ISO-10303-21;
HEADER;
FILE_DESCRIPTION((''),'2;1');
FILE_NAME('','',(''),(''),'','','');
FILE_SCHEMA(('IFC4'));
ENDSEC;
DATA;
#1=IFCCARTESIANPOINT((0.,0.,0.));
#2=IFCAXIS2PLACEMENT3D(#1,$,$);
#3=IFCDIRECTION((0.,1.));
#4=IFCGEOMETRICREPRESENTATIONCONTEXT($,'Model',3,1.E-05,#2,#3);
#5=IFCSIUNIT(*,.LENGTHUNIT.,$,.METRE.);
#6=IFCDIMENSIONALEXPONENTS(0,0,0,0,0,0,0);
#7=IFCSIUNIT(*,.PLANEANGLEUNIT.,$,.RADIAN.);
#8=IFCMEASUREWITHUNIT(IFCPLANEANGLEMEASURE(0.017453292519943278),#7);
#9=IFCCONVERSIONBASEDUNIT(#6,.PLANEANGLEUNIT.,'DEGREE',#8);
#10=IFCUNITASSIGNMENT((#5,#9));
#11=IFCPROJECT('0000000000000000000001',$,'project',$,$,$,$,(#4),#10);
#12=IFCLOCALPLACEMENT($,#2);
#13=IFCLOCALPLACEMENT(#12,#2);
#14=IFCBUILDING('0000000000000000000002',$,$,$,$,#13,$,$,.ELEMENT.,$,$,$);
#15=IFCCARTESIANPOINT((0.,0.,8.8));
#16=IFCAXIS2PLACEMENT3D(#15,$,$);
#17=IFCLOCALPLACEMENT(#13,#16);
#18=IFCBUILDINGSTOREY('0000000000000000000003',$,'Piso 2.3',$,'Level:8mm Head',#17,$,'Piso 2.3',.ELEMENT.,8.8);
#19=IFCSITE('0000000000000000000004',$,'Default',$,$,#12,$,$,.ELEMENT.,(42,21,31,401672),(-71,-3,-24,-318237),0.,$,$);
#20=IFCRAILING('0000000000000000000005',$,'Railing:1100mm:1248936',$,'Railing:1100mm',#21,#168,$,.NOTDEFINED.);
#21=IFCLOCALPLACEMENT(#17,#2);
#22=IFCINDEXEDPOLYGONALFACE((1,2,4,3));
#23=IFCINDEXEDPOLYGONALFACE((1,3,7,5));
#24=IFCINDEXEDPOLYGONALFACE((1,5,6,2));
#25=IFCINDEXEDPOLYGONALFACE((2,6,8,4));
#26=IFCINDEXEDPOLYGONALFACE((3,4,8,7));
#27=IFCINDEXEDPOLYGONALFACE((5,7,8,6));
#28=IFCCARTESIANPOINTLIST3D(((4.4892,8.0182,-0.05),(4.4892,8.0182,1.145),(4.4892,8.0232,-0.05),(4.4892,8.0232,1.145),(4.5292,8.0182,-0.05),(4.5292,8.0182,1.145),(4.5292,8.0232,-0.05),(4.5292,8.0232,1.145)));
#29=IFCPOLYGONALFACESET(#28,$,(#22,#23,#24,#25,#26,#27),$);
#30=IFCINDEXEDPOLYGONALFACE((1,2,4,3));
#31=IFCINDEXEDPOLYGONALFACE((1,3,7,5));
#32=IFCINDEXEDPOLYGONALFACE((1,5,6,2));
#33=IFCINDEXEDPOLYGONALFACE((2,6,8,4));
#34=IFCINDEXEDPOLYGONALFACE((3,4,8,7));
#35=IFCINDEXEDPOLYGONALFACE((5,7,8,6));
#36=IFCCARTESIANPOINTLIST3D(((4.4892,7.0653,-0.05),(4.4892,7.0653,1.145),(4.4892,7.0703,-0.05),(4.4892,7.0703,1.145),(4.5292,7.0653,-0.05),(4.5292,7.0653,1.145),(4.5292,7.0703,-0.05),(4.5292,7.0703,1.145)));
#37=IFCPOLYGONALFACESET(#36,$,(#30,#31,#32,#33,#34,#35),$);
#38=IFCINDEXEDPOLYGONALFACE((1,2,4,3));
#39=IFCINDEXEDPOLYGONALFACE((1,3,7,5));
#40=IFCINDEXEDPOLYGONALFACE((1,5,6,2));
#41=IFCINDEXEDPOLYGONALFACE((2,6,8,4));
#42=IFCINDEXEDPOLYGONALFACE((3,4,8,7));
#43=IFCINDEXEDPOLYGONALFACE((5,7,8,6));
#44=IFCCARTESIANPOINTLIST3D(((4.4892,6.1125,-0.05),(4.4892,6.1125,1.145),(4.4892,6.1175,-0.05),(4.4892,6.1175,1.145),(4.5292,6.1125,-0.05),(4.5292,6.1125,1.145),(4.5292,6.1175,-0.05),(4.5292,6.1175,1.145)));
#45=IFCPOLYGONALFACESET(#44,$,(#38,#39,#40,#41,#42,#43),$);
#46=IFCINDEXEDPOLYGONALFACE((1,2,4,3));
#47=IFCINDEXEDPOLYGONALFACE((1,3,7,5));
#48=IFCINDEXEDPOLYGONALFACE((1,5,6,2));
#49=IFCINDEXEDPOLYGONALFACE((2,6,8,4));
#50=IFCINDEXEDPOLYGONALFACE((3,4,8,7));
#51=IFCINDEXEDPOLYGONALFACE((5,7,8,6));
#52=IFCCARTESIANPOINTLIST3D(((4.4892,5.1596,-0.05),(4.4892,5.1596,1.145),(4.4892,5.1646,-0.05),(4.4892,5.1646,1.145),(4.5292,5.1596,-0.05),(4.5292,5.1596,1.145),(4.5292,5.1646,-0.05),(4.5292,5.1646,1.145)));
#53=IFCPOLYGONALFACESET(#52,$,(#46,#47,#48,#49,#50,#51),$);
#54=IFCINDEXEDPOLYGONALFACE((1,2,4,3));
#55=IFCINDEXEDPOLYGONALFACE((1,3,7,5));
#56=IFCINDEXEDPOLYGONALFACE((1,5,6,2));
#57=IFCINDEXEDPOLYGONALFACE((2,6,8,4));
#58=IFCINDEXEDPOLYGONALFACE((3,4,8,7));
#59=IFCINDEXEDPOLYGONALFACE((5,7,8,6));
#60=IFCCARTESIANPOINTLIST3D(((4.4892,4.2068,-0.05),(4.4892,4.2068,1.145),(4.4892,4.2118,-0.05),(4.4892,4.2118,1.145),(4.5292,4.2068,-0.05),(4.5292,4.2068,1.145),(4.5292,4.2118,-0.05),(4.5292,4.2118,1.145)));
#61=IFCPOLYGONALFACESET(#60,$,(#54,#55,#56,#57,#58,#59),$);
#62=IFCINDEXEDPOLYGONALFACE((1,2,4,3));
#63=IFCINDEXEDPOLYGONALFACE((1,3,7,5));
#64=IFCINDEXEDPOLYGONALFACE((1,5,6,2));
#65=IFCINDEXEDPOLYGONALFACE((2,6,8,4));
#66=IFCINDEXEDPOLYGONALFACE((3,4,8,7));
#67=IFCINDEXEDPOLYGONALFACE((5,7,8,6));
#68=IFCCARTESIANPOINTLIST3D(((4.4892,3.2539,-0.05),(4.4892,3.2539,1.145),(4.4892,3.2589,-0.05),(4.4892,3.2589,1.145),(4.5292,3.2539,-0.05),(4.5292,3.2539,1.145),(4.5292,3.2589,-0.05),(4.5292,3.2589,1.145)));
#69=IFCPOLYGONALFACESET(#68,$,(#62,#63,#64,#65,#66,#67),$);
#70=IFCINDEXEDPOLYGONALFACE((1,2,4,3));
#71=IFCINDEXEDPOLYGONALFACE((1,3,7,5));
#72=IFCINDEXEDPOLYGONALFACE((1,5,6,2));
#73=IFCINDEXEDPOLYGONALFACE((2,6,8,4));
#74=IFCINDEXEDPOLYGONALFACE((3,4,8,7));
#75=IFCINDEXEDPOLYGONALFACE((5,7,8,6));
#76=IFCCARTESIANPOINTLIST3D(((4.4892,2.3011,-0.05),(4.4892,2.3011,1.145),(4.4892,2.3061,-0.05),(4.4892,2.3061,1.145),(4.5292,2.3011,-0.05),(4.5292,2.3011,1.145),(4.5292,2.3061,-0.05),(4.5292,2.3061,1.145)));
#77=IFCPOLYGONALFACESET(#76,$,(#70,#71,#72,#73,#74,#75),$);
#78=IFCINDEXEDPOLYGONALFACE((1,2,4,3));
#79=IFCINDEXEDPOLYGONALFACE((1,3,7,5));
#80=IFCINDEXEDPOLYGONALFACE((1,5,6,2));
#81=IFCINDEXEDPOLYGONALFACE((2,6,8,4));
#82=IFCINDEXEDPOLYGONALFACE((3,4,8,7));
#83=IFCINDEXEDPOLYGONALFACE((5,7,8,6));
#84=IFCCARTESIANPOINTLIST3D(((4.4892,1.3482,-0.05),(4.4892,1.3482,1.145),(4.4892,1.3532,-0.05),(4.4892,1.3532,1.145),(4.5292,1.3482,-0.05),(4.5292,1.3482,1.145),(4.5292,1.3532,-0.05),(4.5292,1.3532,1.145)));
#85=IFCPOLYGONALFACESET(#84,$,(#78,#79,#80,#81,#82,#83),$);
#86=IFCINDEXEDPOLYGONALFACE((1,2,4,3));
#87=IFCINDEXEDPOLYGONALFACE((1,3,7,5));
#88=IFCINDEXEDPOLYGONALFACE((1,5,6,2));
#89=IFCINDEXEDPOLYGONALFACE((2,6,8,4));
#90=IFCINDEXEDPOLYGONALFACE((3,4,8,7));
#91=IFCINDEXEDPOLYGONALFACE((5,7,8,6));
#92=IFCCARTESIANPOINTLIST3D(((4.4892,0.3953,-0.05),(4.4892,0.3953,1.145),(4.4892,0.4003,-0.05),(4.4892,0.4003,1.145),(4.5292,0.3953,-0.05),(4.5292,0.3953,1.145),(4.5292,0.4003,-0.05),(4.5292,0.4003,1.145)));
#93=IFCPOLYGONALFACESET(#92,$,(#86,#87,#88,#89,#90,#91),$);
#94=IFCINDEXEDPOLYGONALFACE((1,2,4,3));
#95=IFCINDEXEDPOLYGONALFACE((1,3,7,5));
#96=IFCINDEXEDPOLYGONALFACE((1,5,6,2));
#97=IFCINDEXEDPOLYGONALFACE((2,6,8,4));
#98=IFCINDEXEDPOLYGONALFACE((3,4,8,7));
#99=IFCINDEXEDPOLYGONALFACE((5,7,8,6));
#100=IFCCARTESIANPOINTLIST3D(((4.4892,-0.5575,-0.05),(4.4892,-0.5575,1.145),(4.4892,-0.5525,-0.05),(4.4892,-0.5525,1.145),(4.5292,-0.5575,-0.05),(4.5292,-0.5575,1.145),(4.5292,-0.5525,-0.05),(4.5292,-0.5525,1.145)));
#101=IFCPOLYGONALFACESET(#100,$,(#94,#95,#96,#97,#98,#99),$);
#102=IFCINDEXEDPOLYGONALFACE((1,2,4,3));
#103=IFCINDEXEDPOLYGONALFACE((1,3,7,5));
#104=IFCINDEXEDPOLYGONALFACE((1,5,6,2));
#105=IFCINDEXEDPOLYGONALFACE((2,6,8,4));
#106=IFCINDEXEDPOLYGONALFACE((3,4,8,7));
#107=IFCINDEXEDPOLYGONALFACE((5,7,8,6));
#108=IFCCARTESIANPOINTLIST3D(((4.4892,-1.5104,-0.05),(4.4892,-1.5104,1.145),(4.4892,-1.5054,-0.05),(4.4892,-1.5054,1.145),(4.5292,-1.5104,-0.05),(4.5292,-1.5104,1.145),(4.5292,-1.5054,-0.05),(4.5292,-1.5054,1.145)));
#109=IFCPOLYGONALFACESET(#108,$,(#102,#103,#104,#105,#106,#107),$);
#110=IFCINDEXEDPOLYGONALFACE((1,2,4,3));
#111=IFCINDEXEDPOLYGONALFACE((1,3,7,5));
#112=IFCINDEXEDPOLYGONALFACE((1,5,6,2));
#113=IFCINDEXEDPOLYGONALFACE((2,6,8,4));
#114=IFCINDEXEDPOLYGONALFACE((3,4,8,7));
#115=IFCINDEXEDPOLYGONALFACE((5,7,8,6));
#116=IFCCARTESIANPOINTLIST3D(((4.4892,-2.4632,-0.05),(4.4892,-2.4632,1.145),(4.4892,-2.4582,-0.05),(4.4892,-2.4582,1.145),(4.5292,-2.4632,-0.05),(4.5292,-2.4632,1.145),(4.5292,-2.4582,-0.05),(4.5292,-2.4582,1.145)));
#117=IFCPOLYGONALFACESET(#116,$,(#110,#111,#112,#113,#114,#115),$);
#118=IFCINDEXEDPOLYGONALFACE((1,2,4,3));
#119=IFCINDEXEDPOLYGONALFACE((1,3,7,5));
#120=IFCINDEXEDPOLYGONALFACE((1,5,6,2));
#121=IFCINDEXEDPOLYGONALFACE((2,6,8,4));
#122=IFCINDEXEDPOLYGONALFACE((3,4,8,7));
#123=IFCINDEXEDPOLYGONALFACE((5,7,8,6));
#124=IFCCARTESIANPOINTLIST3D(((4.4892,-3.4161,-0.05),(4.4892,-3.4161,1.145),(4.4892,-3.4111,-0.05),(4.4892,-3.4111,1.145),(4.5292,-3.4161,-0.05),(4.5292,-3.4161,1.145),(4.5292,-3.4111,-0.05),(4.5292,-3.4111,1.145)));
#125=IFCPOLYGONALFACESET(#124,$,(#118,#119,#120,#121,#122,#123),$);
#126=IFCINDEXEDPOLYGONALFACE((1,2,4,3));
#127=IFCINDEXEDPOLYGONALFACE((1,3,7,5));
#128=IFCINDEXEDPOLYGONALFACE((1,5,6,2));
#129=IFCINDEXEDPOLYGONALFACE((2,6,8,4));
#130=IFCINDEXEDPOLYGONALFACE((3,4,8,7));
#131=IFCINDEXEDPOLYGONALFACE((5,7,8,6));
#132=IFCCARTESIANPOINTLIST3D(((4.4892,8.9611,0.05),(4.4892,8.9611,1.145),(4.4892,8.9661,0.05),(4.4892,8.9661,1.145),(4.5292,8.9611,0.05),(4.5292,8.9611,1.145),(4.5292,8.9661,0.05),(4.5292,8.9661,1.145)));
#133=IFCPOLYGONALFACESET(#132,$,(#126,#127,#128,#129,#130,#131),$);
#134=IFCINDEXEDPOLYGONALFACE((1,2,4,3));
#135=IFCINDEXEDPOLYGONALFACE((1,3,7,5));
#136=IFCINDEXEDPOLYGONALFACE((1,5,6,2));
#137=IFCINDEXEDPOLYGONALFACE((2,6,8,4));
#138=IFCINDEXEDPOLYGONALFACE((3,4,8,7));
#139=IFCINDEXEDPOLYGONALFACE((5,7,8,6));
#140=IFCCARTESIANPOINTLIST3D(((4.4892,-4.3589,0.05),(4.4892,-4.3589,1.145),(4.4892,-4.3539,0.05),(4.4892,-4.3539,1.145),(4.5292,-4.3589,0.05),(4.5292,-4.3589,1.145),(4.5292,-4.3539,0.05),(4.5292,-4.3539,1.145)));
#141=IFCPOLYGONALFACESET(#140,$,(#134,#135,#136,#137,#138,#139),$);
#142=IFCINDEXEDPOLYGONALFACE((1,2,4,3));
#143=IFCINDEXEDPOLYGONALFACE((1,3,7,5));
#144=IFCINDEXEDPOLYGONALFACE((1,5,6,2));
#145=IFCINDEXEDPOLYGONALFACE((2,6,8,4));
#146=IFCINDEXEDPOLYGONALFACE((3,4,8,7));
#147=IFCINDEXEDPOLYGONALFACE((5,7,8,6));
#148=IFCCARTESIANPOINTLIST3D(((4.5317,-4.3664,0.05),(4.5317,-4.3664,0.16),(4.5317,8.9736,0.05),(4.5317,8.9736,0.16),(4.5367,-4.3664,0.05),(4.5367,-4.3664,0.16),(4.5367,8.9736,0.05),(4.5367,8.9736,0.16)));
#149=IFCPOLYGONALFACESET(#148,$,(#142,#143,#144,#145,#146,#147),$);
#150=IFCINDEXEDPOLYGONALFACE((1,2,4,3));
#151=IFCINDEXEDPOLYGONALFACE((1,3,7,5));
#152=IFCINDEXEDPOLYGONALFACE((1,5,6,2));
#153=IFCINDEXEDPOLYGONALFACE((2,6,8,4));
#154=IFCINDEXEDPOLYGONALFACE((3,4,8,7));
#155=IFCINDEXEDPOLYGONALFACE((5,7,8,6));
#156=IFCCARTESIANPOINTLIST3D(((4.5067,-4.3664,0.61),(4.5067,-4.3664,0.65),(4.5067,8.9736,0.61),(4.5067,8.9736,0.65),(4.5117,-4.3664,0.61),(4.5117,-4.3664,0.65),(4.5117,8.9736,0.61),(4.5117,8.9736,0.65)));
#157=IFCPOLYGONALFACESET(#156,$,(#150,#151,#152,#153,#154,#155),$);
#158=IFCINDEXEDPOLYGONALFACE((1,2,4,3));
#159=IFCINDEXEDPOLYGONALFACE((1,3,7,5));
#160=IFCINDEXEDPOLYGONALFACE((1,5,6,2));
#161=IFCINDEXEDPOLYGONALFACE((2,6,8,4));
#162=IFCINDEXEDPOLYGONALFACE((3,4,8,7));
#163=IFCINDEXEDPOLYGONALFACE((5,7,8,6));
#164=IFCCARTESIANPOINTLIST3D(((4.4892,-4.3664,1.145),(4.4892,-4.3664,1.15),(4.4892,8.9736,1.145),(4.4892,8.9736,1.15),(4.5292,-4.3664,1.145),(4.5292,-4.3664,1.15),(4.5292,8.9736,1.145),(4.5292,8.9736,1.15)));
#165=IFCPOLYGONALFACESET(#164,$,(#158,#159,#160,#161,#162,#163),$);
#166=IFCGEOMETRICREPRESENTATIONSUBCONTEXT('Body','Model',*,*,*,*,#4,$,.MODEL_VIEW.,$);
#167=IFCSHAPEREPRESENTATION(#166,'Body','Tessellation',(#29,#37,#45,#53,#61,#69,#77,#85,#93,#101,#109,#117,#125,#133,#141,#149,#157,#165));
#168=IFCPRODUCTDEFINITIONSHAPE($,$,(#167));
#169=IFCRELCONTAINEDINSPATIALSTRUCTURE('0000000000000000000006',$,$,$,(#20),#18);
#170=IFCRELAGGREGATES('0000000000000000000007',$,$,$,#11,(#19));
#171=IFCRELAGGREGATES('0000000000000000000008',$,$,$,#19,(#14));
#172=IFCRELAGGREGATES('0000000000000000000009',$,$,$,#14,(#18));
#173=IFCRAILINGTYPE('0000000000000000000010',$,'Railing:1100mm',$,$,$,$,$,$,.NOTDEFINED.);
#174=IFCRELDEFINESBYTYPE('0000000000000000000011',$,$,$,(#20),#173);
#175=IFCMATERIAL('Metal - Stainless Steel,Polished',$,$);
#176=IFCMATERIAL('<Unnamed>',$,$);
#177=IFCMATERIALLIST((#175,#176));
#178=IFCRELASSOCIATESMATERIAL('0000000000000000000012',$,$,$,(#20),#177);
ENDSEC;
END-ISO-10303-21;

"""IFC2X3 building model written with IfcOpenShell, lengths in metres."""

from ifc_helpers import new_model, entity, si_unit, converted_unit, direction, frame, frame_2d, origin, origin_2d_with_axis, place, context, subcontext, project, spatial, rectangle, extrude, material, material_list, type_object, element, save


model = new_model("IFC2X3")

# Units and contexts
model_context = context("Model", 3, precision=1e-05, world=origin(), true_north=direction((0.0, 1.0)))
body_context = subcontext(model_context, "Body", "Model", "MODEL_VIEW")
ifc_project = project(units=[si_unit("LENGTHUNIT", "METRE"), converted_unit("PLANEANGLEUNIT", "DEGREE", entity("IfcPlaneAngleMeasure", 0.017453292519943278), si_unit("PLANEANGLEUNIT", "RADIAN"), dimensions=[0, 0, 0, 0, 0, 0, 0])], contexts=[model_context])

# Site, building, storey
site_placement = place(None, origin())
site = spatial("IfcSite", under=ifc_project, at=site_placement, Name="Default", CompositionType="ELEMENT", RefLatitude=(42, 21, 31, 401672), RefLongitude=(-71, -3, -24, -318237), RefElevation=0.0)
building_placement = place(site_placement, origin())
building = spatial("IfcBuilding", under=site, at=building_placement, CompositionType="ELEMENT")
storey_placement = place(building_placement, frame((0.0, 0.0, 8.8)))
storey = spatial("IfcBuildingStorey", under=building, at=storey_placement, Name="Piso 2.3", ObjectType="Level:8mm Head", LongName="Piso 2.3", CompositionType="ELEMENT", Elevation=8.8)

# Railing
ifc_material_1 = material(Name="Metal - Stainless Steel,Polished")
ifc_material_2 = material(Name="<Unnamed>")
ifc_material_list = material_list([ifc_material_1, ifc_material_2])
railing_type = type_object("IfcRailingType", Name="Railing:1100mm", PredefinedType="NOTDEFINED")
railing_1_placement = place(storey_placement, origin())
element("IfcRailing", 1, at=railing_1_placement, inside=storey, type_object=railing_type, material=ifc_material_list, Name="Railing:1100mm:1248936", ObjectType="Railing:1100mm", PredefinedType="NOTDEFINED", context=body_context, shape_type="SweptSolid", body=[
    extrude(rectangle(XDim=0.005, YDim=0.04, at=frame_2d((0.0, 0.0), x_axis=(1.0, 0.0))), frame((4.5092, 8.0207, -0.05), z_axis=(0.0, 0.0, 1.0), x_axis=(0.0, 1.0, 0.0)), (0.0, 0.0, 1.0), 1.195),
    extrude(rectangle(XDim=0.005, YDim=0.04, at=frame_2d((0.0, 0.0), x_axis=(1.0, 0.0))), frame((4.5092, 7.0678, -0.05), z_axis=(0.0, 0.0, 1.0), x_axis=(0.0, 1.0, 0.0)), (0.0, 0.0, 1.0), 1.195),
    extrude(rectangle(XDim=0.005, YDim=0.04, at=frame_2d((0.0, 0.0), x_axis=(1.0, 0.0))), frame((4.5092, 6.115, -0.05), z_axis=(0.0, 0.0, 1.0), x_axis=(0.0, 1.0, 0.0)), (0.0, 0.0, 1.0), 1.195),
    extrude(rectangle(XDim=0.005, YDim=0.04, at=frame_2d((0.0, 0.0), x_axis=(1.0, 0.0))), frame((4.5092, 5.1621, -0.05), z_axis=(0.0, 0.0, 1.0), x_axis=(0.0, 1.0, 0.0)), (0.0, 0.0, 1.0), 1.195),
    extrude(rectangle(XDim=0.005, YDim=0.04, at=frame_2d((0.0, 0.0), x_axis=(1.0, 0.0))), frame((4.5092, 4.2093, -0.05), z_axis=(0.0, 0.0, 1.0), x_axis=(0.0, 1.0, 0.0)), (0.0, 0.0, 1.0), 1.195),
    extrude(rectangle(XDim=0.005, YDim=0.04, at=frame_2d((0.0, 0.0), x_axis=(1.0, 0.0))), frame((4.5092, 3.2564, -0.05), z_axis=(0.0, 0.0, 1.0), x_axis=(0.0, 1.0, 0.0)), (0.0, 0.0, 1.0), 1.195),
    extrude(rectangle(XDim=0.005, YDim=0.04, at=frame_2d((0.0, 0.0), x_axis=(1.0, 0.0))), frame((4.5092, 2.3036, -0.05), z_axis=(0.0, 0.0, 1.0), x_axis=(0.0, 1.0, 0.0)), (0.0, 0.0, 1.0), 1.195),
    extrude(rectangle(XDim=0.005, YDim=0.04, at=frame_2d((0.0, 0.0), x_axis=(1.0, 0.0))), frame((4.5092, 1.3507, -0.05), z_axis=(0.0, 0.0, 1.0), x_axis=(0.0, 1.0, 0.0)), (0.0, 0.0, 1.0), 1.195),
    extrude(rectangle(XDim=0.005, YDim=0.04, at=frame_2d((0.0, 0.0), x_axis=(1.0, 0.0))), frame((4.5092, 0.3978, -0.05), z_axis=(0.0, 0.0, 1.0), x_axis=(0.0, 1.0, 0.0)), (0.0, 0.0, 1.0), 1.195),
    extrude(rectangle(XDim=0.005, YDim=0.04, at=frame_2d((0.0, 0.0), x_axis=(1.0, 0.0))), frame((4.5092, -0.555, -0.05), z_axis=(0.0, 0.0, 1.0), x_axis=(0.0, 1.0, 0.0)), (0.0, 0.0, 1.0), 1.195),
    extrude(rectangle(XDim=0.005, YDim=0.04, at=frame_2d((0.0, 0.0), x_axis=(1.0, 0.0))), frame((4.5092, -1.5079, -0.05), z_axis=(0.0, 0.0, 1.0), x_axis=(0.0, 1.0, 0.0)), (0.0, 0.0, 1.0), 1.195),
    extrude(rectangle(XDim=0.005, YDim=0.04, at=frame_2d((0.0, 0.0), x_axis=(1.0, 0.0))), frame((4.5092, -2.4607, -0.05), z_axis=(0.0, 0.0, 1.0), x_axis=(0.0, 1.0, 0.0)), (0.0, 0.0, 1.0), 1.195),
    extrude(rectangle(XDim=0.005, YDim=0.04, at=frame_2d((0.0, 0.0), x_axis=(1.0, 0.0))), frame((4.5092, -3.4136, -0.05), z_axis=(0.0, 0.0, 1.0), x_axis=(0.0, 1.0, 0.0)), (0.0, 0.0, 1.0), 1.195),
    extrude(rectangle(XDim=0.005, YDim=0.04, at=frame_2d((0.0, 0.0), x_axis=(1.0, 0.0))), frame((4.5092, 8.9636, 0.05), z_axis=(0.0, 0.0, 1.0), x_axis=(0.0, 1.0, 0.0)), (0.0, 0.0, 1.0), 1.095),
    extrude(rectangle(XDim=0.005, YDim=0.04, at=frame_2d((0.0, 0.0), x_axis=(1.0, 0.0))), frame((4.5092, -4.3564, 0.05), z_axis=(0.0, 0.0, 1.0), x_axis=(0.0, 1.0, 0.0)), (0.0, 0.0, 1.0), 1.095),
    extrude(rectangle(XDim=13.34, YDim=0.005, at=frame_2d((0.0, 0.0), x_axis=(1.0, 0.0))), frame((4.5342, 2.3036, 0.05), z_axis=(0.0, 0.0, 1.0), x_axis=(0.0, 1.0, 0.0)), (0.0, 0.0, 1.0), 0.11),
    extrude(rectangle(XDim=13.34, YDim=0.005, at=frame_2d((0.0, 0.0), x_axis=(1.0, 0.0))), frame((4.5092, 2.3036, 0.61), z_axis=(0.0, 0.0, 1.0), x_axis=(0.0, 1.0, 0.0)), (0.0, 0.0, 1.0), 0.04),
    extrude(rectangle(XDim=13.34, YDim=0.04, at=origin_2d_with_axis()), frame((4.5092, 2.3036, 1.145), z_axis=(0.0, 0.0, 1.0), x_axis=(0.0, 1.0, 0.0)), (0.0, 0.0, 1.0), 0.005),
])

save(model, "model.ifc")
